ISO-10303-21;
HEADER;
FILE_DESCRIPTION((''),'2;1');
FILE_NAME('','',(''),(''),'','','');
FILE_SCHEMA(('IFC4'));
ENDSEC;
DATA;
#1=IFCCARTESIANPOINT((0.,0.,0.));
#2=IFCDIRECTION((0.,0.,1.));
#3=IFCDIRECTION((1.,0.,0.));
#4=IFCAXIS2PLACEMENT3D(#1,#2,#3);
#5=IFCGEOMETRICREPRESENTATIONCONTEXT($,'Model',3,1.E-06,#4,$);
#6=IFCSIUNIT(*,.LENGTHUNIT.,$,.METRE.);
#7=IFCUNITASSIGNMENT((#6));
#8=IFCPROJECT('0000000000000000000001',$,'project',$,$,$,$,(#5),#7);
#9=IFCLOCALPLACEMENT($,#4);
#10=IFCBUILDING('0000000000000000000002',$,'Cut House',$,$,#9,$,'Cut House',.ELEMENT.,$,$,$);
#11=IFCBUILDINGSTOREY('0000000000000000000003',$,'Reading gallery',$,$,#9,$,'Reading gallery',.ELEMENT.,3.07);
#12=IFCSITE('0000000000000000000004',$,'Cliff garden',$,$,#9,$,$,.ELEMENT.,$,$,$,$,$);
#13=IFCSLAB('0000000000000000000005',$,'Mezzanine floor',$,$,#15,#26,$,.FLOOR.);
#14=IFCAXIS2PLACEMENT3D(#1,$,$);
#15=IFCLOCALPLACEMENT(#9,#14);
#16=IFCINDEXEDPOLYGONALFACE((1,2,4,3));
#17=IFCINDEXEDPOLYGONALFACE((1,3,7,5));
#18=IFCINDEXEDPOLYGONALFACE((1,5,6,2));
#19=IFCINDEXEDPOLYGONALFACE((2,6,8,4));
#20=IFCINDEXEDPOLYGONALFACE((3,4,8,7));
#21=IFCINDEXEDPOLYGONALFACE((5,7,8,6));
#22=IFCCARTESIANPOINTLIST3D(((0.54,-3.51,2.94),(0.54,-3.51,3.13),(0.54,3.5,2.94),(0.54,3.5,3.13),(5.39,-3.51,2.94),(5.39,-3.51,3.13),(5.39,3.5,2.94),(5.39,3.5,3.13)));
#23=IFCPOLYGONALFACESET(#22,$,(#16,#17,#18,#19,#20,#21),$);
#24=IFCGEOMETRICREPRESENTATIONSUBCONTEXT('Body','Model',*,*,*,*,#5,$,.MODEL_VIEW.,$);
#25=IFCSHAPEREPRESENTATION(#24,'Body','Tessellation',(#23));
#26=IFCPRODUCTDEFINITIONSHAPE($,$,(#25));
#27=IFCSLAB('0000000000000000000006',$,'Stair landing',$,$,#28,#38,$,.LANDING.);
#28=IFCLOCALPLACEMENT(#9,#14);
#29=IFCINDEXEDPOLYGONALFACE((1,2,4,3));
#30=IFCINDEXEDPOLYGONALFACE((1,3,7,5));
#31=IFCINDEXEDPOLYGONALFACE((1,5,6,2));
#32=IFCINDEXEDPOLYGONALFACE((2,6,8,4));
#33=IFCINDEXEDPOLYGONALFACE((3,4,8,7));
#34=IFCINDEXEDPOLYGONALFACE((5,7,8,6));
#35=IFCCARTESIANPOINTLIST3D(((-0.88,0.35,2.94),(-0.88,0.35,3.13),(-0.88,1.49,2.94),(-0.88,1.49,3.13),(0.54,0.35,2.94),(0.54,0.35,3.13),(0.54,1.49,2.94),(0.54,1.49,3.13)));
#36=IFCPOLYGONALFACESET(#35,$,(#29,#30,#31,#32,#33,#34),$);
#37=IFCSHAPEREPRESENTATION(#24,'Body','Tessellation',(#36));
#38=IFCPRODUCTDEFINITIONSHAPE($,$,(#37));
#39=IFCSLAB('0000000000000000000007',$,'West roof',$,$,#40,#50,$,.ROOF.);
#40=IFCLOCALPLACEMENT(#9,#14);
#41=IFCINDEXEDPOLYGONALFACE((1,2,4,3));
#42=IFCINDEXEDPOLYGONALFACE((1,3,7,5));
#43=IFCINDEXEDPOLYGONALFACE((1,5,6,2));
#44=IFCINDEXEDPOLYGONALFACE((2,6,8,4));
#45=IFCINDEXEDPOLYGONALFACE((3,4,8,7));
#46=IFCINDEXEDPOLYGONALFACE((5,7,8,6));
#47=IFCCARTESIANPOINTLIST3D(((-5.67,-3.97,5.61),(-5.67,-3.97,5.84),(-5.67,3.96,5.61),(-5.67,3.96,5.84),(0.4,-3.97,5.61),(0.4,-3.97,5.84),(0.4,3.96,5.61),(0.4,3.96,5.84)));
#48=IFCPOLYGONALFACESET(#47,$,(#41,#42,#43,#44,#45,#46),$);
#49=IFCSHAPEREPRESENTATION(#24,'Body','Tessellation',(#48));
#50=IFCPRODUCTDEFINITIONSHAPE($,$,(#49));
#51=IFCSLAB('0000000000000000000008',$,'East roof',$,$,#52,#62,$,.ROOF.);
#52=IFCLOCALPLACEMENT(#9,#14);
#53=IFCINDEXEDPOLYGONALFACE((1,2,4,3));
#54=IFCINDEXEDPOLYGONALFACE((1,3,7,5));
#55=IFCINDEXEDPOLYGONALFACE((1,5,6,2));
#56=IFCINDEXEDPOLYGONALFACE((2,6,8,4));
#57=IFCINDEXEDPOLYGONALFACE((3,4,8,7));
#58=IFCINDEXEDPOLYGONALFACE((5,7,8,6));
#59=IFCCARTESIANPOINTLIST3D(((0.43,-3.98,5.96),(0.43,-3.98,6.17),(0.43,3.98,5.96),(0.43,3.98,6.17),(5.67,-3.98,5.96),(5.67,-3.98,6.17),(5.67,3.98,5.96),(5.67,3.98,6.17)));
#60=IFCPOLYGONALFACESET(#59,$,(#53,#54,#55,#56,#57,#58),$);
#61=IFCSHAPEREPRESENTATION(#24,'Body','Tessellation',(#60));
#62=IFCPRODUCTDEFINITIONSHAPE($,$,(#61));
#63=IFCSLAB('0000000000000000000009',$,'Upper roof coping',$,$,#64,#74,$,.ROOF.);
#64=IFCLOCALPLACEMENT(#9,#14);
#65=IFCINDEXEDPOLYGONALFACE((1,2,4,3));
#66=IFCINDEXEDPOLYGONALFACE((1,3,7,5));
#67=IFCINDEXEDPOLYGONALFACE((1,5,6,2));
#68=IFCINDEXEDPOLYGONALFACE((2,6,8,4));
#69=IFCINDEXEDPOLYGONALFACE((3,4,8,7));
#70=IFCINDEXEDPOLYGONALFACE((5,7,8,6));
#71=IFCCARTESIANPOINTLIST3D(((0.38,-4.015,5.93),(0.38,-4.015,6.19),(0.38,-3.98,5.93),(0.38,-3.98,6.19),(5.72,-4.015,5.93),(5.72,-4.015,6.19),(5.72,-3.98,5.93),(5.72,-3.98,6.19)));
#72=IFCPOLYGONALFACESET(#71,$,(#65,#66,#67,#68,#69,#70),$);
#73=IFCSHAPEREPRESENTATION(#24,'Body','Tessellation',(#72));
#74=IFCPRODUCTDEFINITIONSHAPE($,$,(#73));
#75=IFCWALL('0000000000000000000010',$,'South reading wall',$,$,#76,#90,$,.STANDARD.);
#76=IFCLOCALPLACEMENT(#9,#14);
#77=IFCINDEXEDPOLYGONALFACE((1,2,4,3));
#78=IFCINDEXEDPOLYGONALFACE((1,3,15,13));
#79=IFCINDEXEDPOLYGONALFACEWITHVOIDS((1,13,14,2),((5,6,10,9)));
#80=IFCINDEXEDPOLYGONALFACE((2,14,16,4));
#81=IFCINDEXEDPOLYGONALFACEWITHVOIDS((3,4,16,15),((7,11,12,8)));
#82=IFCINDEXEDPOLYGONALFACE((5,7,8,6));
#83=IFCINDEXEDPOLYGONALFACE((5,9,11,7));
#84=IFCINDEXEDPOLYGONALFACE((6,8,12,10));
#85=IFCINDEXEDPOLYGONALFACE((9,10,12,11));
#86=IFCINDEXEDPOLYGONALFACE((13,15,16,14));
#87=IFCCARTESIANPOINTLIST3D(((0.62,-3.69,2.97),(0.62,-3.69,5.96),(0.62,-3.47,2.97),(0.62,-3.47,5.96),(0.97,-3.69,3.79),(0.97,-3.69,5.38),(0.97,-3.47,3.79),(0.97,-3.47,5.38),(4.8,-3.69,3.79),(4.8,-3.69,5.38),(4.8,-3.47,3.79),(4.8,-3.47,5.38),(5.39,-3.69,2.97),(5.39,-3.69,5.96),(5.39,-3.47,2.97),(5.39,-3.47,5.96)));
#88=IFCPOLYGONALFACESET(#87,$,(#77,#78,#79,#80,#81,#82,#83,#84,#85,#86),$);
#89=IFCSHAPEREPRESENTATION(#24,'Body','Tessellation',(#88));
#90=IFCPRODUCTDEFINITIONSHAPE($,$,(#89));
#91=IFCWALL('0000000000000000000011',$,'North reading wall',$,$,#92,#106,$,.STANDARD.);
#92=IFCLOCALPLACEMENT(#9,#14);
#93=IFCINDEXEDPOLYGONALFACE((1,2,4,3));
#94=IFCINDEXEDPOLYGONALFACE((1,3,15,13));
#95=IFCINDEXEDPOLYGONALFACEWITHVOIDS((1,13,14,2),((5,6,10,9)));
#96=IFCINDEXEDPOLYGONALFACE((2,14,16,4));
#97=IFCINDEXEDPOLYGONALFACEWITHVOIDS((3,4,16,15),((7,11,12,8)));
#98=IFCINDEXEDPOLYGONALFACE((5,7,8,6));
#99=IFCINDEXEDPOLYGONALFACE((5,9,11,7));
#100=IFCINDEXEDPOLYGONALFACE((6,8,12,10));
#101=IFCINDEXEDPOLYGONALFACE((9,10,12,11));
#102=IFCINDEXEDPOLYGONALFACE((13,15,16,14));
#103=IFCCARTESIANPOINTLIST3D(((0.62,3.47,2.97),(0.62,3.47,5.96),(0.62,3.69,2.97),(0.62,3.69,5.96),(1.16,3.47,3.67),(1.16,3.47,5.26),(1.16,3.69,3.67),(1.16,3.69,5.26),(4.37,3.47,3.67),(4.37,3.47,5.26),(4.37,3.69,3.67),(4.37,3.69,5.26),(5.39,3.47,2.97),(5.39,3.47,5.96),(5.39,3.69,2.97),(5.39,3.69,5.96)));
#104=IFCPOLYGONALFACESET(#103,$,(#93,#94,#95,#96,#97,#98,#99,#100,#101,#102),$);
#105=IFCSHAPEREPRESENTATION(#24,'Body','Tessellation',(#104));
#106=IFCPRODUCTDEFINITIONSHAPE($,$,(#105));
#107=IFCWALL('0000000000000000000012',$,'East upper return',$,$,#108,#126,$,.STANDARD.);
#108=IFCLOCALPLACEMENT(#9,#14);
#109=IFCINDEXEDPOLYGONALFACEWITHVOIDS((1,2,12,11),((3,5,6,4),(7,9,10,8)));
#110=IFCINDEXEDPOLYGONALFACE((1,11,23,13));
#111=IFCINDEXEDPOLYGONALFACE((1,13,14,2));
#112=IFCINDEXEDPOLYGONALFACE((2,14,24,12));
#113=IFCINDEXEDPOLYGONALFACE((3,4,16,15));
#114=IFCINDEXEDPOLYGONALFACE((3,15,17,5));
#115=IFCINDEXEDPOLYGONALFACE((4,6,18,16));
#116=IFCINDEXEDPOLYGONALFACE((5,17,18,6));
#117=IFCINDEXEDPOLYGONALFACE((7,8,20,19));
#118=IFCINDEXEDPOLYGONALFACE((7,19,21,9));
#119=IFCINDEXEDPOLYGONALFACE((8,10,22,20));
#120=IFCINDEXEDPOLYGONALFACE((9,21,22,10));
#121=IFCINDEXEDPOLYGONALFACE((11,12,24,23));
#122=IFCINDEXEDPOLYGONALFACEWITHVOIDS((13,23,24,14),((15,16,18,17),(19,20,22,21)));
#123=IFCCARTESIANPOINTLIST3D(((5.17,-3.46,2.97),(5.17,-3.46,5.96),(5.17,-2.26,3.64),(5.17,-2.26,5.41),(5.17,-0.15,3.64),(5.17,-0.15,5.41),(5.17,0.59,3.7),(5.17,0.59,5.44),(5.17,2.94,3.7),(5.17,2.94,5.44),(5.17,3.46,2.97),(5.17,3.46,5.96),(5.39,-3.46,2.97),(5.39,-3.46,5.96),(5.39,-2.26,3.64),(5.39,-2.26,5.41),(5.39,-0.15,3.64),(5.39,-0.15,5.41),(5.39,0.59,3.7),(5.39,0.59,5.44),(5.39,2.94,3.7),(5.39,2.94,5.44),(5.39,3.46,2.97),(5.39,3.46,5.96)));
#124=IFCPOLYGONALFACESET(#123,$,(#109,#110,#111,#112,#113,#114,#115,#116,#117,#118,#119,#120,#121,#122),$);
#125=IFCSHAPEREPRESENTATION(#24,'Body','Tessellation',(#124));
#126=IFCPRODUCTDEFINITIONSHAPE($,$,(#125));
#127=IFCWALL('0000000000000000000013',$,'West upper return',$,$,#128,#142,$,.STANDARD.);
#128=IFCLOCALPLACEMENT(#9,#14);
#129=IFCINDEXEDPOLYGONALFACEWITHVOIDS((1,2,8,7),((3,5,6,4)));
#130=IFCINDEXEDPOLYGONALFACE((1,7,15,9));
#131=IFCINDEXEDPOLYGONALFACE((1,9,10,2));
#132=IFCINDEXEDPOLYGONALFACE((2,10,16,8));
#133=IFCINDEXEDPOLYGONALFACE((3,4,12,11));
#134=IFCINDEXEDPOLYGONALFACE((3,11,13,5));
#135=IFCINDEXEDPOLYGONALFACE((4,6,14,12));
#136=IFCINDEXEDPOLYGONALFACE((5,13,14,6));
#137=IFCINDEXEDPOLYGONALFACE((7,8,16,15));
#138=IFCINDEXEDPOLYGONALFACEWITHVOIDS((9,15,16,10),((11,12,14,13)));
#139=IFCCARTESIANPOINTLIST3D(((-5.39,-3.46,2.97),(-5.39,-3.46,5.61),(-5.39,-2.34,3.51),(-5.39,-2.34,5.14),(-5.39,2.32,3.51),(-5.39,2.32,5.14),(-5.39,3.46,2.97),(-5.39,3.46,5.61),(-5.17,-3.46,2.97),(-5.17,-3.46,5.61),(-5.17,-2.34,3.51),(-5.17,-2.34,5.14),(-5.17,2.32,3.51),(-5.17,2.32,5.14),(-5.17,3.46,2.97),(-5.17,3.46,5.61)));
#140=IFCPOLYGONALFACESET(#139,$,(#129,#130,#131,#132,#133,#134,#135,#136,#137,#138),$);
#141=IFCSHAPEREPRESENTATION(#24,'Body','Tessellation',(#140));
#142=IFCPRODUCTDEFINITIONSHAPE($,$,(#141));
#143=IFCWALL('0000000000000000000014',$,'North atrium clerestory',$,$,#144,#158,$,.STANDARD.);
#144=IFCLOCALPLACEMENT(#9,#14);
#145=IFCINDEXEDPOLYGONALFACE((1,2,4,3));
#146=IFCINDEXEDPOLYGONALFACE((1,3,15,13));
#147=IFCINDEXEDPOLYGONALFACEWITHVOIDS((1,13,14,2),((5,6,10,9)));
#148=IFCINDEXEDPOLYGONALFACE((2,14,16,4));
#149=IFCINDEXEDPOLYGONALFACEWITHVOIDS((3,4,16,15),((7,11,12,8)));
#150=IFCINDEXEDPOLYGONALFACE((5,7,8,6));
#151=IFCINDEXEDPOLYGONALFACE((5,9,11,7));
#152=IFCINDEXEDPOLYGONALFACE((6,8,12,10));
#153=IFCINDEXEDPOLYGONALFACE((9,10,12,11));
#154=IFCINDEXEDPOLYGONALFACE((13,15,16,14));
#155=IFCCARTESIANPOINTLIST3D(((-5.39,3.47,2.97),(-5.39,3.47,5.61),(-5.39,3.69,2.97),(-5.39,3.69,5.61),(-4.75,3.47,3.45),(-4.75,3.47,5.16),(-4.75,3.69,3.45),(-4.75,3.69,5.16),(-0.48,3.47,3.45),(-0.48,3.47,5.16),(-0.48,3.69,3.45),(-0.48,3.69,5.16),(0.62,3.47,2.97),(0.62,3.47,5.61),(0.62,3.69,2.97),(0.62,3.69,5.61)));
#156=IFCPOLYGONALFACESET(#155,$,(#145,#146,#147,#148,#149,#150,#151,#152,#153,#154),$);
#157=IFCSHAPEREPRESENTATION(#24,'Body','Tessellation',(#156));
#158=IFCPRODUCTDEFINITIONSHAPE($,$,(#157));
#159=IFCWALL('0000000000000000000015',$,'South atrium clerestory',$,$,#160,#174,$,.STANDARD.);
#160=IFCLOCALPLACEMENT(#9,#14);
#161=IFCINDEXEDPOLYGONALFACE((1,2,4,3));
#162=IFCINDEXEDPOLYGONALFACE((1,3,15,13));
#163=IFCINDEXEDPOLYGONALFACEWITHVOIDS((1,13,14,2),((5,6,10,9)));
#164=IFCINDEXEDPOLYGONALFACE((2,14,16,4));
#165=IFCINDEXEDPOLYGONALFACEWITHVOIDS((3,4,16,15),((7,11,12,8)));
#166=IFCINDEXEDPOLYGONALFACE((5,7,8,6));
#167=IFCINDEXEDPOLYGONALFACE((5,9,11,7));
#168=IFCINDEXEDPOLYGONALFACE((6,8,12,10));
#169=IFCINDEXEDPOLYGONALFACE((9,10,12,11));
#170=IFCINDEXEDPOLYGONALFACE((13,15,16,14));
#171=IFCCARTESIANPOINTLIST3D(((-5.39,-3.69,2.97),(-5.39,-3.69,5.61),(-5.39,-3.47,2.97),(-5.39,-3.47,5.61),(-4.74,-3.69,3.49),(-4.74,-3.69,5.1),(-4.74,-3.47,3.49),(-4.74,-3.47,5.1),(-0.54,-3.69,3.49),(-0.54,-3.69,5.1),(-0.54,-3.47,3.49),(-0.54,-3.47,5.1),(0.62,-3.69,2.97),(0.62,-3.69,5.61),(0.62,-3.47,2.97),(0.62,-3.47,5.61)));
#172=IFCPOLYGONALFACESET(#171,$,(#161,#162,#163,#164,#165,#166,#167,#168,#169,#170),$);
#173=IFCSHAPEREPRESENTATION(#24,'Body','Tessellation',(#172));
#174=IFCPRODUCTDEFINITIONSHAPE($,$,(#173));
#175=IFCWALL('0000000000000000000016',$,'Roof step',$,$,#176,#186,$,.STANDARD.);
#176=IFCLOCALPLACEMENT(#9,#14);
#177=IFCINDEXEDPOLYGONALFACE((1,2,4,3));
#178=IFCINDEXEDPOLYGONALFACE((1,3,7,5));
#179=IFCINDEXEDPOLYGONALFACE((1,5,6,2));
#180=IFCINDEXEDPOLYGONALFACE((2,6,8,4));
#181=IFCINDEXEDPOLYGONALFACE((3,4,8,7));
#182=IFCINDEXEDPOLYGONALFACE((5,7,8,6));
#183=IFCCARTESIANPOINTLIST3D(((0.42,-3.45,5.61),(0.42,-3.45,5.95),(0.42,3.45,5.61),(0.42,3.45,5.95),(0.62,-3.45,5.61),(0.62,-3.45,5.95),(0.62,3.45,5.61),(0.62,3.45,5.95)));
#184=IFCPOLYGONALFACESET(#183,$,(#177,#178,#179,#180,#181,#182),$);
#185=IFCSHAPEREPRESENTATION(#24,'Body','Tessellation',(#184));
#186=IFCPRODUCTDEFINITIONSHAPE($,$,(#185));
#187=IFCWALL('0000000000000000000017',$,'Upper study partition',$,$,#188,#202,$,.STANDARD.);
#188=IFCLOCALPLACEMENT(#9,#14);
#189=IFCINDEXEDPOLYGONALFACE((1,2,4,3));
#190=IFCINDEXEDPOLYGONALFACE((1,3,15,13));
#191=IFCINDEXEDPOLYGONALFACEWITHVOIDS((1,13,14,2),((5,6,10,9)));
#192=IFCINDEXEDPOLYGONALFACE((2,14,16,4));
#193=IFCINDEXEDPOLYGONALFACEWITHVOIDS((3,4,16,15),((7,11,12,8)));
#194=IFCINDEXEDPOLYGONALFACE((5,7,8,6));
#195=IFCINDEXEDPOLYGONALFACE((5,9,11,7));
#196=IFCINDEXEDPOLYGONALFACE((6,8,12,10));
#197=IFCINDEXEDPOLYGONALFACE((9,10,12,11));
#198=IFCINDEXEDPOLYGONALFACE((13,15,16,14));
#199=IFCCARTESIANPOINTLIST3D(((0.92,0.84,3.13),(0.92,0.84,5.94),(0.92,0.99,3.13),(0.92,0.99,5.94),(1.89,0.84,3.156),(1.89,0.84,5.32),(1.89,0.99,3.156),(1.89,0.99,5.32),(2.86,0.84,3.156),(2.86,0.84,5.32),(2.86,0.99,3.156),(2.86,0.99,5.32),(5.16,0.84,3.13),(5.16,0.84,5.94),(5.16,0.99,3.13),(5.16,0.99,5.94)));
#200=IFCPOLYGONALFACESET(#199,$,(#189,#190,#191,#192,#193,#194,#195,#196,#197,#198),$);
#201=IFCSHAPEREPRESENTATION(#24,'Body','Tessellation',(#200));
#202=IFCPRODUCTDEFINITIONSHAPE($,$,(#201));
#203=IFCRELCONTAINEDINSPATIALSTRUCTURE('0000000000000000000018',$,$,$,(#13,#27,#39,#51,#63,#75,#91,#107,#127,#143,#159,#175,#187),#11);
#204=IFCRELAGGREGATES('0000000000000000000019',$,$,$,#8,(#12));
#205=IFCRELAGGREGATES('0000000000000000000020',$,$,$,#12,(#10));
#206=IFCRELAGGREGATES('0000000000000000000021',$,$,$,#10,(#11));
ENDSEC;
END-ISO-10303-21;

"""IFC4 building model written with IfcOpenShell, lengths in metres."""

from ifc_helpers import new_model, si_unit, frame, origin_with_axes, place, context, subcontext, project, spatial, polyline, outline, extrude, element, save


model = new_model("IFC4")

# Units and contexts
model_context = context("Model", 3, precision=1e-06, world=origin_with_axes())
body_context = subcontext(model_context, "Body", "Model", "MODEL_VIEW")
ifc_project = project(units=[si_unit("LENGTHUNIT", "METRE")], contexts=[model_context])

# Site, building, storey
placement = place(None, origin_with_axes())
site = spatial("IfcSite", under=ifc_project, at=placement, Name="Cliff garden", CompositionType="ELEMENT")
building = spatial("IfcBuilding", under=site, at=placement, Name="Cut House", LongName="Cut House", CompositionType="ELEMENT")
storey = spatial("IfcBuildingStorey", under=building, at=placement, Name="Reading gallery", LongName="Reading gallery", CompositionType="ELEMENT", Elevation=3.07)

# Slabs
element("IfcSlab", 1, at=placement, inside=storey, Name="Mezzanine floor", PredefinedType="FLOOR", context=body_context, shape_type="SweptSolid", body=[
    extrude(outline(polyline([(0.0, 0.0), (4.85, 0.0), (4.85, 7.01), (0.0, 7.01), (0.0, 0.0)])), frame((0.54, -3.51, 2.94), z_axis=(0.0, 0.0, 1.0), x_axis=(1.0, 0.0, 0.0)), (0.0, 0.0, 1.0), 0.19),
])
element("IfcSlab", 2, at=placement, inside=storey, Name="Stair landing", PredefinedType="LANDING", context=body_context, shape_type="SweptSolid", body=[
    extrude(outline(polyline([(0.0, 0.0), (1.42, 0.0), (1.42, 1.14), (0.0, 1.14), (0.0, 0.0)])), frame((-0.88, 0.35, 2.94), z_axis=(0.0, 0.0, 1.0), x_axis=(1.0, 0.0, 0.0)), (0.0, 0.0, 1.0), 0.19),
])
element("IfcSlab", 3, at=placement, inside=storey, Name="West roof", PredefinedType="ROOF", context=body_context, shape_type="SweptSolid", body=[
    extrude(outline(polyline([(0.0, 0.0), (6.07, 0.0), (6.07, 7.93), (0.0, 7.93), (0.0, 0.0)])), frame((-5.67, -3.97, 5.61), z_axis=(0.0, 0.0, 1.0), x_axis=(1.0, 0.0, 0.0)), (0.0, 0.0, 1.0), 0.23),
])
element("IfcSlab", 4, at=placement, inside=storey, Name="East roof", PredefinedType="ROOF", context=body_context, shape_type="SweptSolid", body=[
    extrude(outline(polyline([(0.0, 0.0), (5.24, 0.0), (5.24, 7.96), (0.0, 7.96), (0.0, 0.0)])), frame((0.43, -3.98, 5.96), z_axis=(0.0, 0.0, 1.0), x_axis=(1.0, 0.0, 0.0)), (0.0, 0.0, 1.0), 0.21),
])
element("IfcSlab", 5, at=placement, inside=storey, Name="Upper roof coping", PredefinedType="ROOF", context=body_context, shape_type="SweptSolid", body=[
    extrude(outline(polyline([(0.0, 0.0), (5.34, 0.0), (5.34, 0.035), (0.0, 0.035), (0.0, 0.0)])), frame((0.38, -4.015, 5.93), z_axis=(0.0, 0.0, 1.0), x_axis=(1.0, 0.0, 0.0)), (0.0, 0.0, 1.0), 0.26),
])

# Walls
element("IfcWall", 6, at=placement, inside=storey, Name="South reading wall", PredefinedType="STANDARD", context=body_context, shape_type="SweptSolid", body=[
    extrude(outline(polyline([(0.0, 0.0), (4.77, 0.0), (4.77, 2.99), (0.0, 2.99), (0.0, 0.0)]), holes=[polyline([(0.35, 0.82), (4.18, 0.82), (4.18, 2.41), (0.35, 2.41), (0.35, 0.82)])]), frame((0.62, -3.47, 2.97), z_axis=(0.0, -1.0, 0.0), x_axis=(1.0, 0.0, 0.0)), (0.0, 0.0, 1.0), 0.22),
])
element("IfcWall", 7, at=placement, inside=storey, Name="North reading wall", PredefinedType="STANDARD", context=body_context, shape_type="SweptSolid", body=[
    extrude(outline(polyline([(0.0, 0.0), (4.77, 0.0), (4.77, 2.99), (0.0, 2.99), (0.0, 0.0)]), holes=[polyline([(0.54, 0.7), (3.75, 0.7), (3.75, 2.29), (0.54, 2.29), (0.54, 0.7)])]), frame((0.62, 3.69, 2.97), z_axis=(0.0, -1.0, 0.0), x_axis=(1.0, 0.0, 0.0)), (0.0, 0.0, 1.0), 0.22),
])
element("IfcWall", 8, at=placement, inside=storey, Name="East upper return", PredefinedType="STANDARD", context=body_context, shape_type="SweptSolid", body=[
    extrude(outline(polyline([(0.0, 0.0), (6.92, 0.0), (6.92, 2.99), (0.0, 2.99), (0.0, 0.0)]), holes=[polyline([(1.2, 0.67), (3.31, 0.67), (3.31, 2.44), (1.2, 2.44), (1.2, 0.67)]), polyline([(4.05, 0.73), (6.4, 0.73), (6.4, 2.47), (4.05, 2.47), (4.05, 0.73)])]), frame((5.17, -3.46, 2.97), z_axis=(1.0, 0.0, 0.0), x_axis=(0.0, 1.0, 0.0)), (0.0, 0.0, 1.0), 0.22),
])
element("IfcWall", 9, at=placement, inside=storey, Name="West upper return", PredefinedType="STANDARD", context=body_context, shape_type="SweptSolid", body=[
    extrude(outline(polyline([(0.0, 0.0), (6.92, 0.0), (6.92, 2.64), (0.0, 2.64), (0.0, 0.0)]), holes=[polyline([(1.12, 0.54), (5.78, 0.54), (5.78, 2.17), (1.12, 2.17), (1.12, 0.54)])]), frame((-5.39, -3.46, 2.97), z_axis=(1.0, 0.0, 0.0), x_axis=(0.0, 1.0, 0.0)), (0.0, 0.0, 1.0), 0.22),
])
element("IfcWall", 10, at=placement, inside=storey, Name="North atrium clerestory", PredefinedType="STANDARD", context=body_context, shape_type="SweptSolid", body=[
    extrude(outline(polyline([(0.0, 0.0), (6.01, 0.0), (6.01, 2.64), (0.0, 2.64), (0.0, 0.0)]), holes=[polyline([(0.64, 0.48), (4.91, 0.48), (4.91, 2.19), (0.64, 2.19), (0.64, 0.48)])]), frame((-5.39, 3.69, 2.97), z_axis=(0.0, -1.0, 0.0), x_axis=(1.0, 0.0, 0.0)), (0.0, 0.0, 1.0), 0.22),
])
element("IfcWall", 11, at=placement, inside=storey, Name="South atrium clerestory", PredefinedType="STANDARD", context=body_context, shape_type="SweptSolid", body=[
    extrude(outline(polyline([(0.0, 0.0), (6.01, 0.0), (6.01, 2.64), (0.0, 2.64), (0.0, 0.0)]), holes=[polyline([(0.65, 0.52), (4.85, 0.52), (4.85, 2.13), (0.65, 2.13), (0.65, 0.52)])]), frame((-5.39, -3.47, 2.97), z_axis=(0.0, -1.0, 0.0), x_axis=(1.0, 0.0, 0.0)), (0.0, 0.0, 1.0), 0.22),
])
element("IfcWall", 12, at=placement, inside=storey, Name="Roof step", PredefinedType="STANDARD", context=body_context, shape_type="SweptSolid", body=[
    extrude(outline(polyline([(0.0, 0.0), (6.9, 0.0), (6.9, 0.34), (0.0, 0.34), (0.0, 0.0)])), frame((0.42, -3.45, 5.61), z_axis=(1.0, 0.0, 0.0), x_axis=(0.0, 1.0, 0.0)), (0.0, 0.0, 1.0), 0.2),
])
element("IfcWall", 13, at=placement, inside=storey, Name="Upper study partition", PredefinedType="STANDARD", context=body_context, shape_type="SweptSolid", body=[
    extrude(outline(polyline([(0.0, 0.0), (4.24, 0.0), (4.24, 2.81), (0.0, 2.81), (0.0, 0.0)]), holes=[polyline([(0.97, 0.026), (1.94, 0.026), (1.94, 2.19), (0.97, 2.19), (0.97, 0.026)])]), frame((0.92, 0.99, 3.13), z_axis=(0.0, -1.0, 0.0), x_axis=(1.0, 0.0, 0.0)), (0.0, 0.0, 1.0), 0.15),
])

save(model, "model.ifc")
